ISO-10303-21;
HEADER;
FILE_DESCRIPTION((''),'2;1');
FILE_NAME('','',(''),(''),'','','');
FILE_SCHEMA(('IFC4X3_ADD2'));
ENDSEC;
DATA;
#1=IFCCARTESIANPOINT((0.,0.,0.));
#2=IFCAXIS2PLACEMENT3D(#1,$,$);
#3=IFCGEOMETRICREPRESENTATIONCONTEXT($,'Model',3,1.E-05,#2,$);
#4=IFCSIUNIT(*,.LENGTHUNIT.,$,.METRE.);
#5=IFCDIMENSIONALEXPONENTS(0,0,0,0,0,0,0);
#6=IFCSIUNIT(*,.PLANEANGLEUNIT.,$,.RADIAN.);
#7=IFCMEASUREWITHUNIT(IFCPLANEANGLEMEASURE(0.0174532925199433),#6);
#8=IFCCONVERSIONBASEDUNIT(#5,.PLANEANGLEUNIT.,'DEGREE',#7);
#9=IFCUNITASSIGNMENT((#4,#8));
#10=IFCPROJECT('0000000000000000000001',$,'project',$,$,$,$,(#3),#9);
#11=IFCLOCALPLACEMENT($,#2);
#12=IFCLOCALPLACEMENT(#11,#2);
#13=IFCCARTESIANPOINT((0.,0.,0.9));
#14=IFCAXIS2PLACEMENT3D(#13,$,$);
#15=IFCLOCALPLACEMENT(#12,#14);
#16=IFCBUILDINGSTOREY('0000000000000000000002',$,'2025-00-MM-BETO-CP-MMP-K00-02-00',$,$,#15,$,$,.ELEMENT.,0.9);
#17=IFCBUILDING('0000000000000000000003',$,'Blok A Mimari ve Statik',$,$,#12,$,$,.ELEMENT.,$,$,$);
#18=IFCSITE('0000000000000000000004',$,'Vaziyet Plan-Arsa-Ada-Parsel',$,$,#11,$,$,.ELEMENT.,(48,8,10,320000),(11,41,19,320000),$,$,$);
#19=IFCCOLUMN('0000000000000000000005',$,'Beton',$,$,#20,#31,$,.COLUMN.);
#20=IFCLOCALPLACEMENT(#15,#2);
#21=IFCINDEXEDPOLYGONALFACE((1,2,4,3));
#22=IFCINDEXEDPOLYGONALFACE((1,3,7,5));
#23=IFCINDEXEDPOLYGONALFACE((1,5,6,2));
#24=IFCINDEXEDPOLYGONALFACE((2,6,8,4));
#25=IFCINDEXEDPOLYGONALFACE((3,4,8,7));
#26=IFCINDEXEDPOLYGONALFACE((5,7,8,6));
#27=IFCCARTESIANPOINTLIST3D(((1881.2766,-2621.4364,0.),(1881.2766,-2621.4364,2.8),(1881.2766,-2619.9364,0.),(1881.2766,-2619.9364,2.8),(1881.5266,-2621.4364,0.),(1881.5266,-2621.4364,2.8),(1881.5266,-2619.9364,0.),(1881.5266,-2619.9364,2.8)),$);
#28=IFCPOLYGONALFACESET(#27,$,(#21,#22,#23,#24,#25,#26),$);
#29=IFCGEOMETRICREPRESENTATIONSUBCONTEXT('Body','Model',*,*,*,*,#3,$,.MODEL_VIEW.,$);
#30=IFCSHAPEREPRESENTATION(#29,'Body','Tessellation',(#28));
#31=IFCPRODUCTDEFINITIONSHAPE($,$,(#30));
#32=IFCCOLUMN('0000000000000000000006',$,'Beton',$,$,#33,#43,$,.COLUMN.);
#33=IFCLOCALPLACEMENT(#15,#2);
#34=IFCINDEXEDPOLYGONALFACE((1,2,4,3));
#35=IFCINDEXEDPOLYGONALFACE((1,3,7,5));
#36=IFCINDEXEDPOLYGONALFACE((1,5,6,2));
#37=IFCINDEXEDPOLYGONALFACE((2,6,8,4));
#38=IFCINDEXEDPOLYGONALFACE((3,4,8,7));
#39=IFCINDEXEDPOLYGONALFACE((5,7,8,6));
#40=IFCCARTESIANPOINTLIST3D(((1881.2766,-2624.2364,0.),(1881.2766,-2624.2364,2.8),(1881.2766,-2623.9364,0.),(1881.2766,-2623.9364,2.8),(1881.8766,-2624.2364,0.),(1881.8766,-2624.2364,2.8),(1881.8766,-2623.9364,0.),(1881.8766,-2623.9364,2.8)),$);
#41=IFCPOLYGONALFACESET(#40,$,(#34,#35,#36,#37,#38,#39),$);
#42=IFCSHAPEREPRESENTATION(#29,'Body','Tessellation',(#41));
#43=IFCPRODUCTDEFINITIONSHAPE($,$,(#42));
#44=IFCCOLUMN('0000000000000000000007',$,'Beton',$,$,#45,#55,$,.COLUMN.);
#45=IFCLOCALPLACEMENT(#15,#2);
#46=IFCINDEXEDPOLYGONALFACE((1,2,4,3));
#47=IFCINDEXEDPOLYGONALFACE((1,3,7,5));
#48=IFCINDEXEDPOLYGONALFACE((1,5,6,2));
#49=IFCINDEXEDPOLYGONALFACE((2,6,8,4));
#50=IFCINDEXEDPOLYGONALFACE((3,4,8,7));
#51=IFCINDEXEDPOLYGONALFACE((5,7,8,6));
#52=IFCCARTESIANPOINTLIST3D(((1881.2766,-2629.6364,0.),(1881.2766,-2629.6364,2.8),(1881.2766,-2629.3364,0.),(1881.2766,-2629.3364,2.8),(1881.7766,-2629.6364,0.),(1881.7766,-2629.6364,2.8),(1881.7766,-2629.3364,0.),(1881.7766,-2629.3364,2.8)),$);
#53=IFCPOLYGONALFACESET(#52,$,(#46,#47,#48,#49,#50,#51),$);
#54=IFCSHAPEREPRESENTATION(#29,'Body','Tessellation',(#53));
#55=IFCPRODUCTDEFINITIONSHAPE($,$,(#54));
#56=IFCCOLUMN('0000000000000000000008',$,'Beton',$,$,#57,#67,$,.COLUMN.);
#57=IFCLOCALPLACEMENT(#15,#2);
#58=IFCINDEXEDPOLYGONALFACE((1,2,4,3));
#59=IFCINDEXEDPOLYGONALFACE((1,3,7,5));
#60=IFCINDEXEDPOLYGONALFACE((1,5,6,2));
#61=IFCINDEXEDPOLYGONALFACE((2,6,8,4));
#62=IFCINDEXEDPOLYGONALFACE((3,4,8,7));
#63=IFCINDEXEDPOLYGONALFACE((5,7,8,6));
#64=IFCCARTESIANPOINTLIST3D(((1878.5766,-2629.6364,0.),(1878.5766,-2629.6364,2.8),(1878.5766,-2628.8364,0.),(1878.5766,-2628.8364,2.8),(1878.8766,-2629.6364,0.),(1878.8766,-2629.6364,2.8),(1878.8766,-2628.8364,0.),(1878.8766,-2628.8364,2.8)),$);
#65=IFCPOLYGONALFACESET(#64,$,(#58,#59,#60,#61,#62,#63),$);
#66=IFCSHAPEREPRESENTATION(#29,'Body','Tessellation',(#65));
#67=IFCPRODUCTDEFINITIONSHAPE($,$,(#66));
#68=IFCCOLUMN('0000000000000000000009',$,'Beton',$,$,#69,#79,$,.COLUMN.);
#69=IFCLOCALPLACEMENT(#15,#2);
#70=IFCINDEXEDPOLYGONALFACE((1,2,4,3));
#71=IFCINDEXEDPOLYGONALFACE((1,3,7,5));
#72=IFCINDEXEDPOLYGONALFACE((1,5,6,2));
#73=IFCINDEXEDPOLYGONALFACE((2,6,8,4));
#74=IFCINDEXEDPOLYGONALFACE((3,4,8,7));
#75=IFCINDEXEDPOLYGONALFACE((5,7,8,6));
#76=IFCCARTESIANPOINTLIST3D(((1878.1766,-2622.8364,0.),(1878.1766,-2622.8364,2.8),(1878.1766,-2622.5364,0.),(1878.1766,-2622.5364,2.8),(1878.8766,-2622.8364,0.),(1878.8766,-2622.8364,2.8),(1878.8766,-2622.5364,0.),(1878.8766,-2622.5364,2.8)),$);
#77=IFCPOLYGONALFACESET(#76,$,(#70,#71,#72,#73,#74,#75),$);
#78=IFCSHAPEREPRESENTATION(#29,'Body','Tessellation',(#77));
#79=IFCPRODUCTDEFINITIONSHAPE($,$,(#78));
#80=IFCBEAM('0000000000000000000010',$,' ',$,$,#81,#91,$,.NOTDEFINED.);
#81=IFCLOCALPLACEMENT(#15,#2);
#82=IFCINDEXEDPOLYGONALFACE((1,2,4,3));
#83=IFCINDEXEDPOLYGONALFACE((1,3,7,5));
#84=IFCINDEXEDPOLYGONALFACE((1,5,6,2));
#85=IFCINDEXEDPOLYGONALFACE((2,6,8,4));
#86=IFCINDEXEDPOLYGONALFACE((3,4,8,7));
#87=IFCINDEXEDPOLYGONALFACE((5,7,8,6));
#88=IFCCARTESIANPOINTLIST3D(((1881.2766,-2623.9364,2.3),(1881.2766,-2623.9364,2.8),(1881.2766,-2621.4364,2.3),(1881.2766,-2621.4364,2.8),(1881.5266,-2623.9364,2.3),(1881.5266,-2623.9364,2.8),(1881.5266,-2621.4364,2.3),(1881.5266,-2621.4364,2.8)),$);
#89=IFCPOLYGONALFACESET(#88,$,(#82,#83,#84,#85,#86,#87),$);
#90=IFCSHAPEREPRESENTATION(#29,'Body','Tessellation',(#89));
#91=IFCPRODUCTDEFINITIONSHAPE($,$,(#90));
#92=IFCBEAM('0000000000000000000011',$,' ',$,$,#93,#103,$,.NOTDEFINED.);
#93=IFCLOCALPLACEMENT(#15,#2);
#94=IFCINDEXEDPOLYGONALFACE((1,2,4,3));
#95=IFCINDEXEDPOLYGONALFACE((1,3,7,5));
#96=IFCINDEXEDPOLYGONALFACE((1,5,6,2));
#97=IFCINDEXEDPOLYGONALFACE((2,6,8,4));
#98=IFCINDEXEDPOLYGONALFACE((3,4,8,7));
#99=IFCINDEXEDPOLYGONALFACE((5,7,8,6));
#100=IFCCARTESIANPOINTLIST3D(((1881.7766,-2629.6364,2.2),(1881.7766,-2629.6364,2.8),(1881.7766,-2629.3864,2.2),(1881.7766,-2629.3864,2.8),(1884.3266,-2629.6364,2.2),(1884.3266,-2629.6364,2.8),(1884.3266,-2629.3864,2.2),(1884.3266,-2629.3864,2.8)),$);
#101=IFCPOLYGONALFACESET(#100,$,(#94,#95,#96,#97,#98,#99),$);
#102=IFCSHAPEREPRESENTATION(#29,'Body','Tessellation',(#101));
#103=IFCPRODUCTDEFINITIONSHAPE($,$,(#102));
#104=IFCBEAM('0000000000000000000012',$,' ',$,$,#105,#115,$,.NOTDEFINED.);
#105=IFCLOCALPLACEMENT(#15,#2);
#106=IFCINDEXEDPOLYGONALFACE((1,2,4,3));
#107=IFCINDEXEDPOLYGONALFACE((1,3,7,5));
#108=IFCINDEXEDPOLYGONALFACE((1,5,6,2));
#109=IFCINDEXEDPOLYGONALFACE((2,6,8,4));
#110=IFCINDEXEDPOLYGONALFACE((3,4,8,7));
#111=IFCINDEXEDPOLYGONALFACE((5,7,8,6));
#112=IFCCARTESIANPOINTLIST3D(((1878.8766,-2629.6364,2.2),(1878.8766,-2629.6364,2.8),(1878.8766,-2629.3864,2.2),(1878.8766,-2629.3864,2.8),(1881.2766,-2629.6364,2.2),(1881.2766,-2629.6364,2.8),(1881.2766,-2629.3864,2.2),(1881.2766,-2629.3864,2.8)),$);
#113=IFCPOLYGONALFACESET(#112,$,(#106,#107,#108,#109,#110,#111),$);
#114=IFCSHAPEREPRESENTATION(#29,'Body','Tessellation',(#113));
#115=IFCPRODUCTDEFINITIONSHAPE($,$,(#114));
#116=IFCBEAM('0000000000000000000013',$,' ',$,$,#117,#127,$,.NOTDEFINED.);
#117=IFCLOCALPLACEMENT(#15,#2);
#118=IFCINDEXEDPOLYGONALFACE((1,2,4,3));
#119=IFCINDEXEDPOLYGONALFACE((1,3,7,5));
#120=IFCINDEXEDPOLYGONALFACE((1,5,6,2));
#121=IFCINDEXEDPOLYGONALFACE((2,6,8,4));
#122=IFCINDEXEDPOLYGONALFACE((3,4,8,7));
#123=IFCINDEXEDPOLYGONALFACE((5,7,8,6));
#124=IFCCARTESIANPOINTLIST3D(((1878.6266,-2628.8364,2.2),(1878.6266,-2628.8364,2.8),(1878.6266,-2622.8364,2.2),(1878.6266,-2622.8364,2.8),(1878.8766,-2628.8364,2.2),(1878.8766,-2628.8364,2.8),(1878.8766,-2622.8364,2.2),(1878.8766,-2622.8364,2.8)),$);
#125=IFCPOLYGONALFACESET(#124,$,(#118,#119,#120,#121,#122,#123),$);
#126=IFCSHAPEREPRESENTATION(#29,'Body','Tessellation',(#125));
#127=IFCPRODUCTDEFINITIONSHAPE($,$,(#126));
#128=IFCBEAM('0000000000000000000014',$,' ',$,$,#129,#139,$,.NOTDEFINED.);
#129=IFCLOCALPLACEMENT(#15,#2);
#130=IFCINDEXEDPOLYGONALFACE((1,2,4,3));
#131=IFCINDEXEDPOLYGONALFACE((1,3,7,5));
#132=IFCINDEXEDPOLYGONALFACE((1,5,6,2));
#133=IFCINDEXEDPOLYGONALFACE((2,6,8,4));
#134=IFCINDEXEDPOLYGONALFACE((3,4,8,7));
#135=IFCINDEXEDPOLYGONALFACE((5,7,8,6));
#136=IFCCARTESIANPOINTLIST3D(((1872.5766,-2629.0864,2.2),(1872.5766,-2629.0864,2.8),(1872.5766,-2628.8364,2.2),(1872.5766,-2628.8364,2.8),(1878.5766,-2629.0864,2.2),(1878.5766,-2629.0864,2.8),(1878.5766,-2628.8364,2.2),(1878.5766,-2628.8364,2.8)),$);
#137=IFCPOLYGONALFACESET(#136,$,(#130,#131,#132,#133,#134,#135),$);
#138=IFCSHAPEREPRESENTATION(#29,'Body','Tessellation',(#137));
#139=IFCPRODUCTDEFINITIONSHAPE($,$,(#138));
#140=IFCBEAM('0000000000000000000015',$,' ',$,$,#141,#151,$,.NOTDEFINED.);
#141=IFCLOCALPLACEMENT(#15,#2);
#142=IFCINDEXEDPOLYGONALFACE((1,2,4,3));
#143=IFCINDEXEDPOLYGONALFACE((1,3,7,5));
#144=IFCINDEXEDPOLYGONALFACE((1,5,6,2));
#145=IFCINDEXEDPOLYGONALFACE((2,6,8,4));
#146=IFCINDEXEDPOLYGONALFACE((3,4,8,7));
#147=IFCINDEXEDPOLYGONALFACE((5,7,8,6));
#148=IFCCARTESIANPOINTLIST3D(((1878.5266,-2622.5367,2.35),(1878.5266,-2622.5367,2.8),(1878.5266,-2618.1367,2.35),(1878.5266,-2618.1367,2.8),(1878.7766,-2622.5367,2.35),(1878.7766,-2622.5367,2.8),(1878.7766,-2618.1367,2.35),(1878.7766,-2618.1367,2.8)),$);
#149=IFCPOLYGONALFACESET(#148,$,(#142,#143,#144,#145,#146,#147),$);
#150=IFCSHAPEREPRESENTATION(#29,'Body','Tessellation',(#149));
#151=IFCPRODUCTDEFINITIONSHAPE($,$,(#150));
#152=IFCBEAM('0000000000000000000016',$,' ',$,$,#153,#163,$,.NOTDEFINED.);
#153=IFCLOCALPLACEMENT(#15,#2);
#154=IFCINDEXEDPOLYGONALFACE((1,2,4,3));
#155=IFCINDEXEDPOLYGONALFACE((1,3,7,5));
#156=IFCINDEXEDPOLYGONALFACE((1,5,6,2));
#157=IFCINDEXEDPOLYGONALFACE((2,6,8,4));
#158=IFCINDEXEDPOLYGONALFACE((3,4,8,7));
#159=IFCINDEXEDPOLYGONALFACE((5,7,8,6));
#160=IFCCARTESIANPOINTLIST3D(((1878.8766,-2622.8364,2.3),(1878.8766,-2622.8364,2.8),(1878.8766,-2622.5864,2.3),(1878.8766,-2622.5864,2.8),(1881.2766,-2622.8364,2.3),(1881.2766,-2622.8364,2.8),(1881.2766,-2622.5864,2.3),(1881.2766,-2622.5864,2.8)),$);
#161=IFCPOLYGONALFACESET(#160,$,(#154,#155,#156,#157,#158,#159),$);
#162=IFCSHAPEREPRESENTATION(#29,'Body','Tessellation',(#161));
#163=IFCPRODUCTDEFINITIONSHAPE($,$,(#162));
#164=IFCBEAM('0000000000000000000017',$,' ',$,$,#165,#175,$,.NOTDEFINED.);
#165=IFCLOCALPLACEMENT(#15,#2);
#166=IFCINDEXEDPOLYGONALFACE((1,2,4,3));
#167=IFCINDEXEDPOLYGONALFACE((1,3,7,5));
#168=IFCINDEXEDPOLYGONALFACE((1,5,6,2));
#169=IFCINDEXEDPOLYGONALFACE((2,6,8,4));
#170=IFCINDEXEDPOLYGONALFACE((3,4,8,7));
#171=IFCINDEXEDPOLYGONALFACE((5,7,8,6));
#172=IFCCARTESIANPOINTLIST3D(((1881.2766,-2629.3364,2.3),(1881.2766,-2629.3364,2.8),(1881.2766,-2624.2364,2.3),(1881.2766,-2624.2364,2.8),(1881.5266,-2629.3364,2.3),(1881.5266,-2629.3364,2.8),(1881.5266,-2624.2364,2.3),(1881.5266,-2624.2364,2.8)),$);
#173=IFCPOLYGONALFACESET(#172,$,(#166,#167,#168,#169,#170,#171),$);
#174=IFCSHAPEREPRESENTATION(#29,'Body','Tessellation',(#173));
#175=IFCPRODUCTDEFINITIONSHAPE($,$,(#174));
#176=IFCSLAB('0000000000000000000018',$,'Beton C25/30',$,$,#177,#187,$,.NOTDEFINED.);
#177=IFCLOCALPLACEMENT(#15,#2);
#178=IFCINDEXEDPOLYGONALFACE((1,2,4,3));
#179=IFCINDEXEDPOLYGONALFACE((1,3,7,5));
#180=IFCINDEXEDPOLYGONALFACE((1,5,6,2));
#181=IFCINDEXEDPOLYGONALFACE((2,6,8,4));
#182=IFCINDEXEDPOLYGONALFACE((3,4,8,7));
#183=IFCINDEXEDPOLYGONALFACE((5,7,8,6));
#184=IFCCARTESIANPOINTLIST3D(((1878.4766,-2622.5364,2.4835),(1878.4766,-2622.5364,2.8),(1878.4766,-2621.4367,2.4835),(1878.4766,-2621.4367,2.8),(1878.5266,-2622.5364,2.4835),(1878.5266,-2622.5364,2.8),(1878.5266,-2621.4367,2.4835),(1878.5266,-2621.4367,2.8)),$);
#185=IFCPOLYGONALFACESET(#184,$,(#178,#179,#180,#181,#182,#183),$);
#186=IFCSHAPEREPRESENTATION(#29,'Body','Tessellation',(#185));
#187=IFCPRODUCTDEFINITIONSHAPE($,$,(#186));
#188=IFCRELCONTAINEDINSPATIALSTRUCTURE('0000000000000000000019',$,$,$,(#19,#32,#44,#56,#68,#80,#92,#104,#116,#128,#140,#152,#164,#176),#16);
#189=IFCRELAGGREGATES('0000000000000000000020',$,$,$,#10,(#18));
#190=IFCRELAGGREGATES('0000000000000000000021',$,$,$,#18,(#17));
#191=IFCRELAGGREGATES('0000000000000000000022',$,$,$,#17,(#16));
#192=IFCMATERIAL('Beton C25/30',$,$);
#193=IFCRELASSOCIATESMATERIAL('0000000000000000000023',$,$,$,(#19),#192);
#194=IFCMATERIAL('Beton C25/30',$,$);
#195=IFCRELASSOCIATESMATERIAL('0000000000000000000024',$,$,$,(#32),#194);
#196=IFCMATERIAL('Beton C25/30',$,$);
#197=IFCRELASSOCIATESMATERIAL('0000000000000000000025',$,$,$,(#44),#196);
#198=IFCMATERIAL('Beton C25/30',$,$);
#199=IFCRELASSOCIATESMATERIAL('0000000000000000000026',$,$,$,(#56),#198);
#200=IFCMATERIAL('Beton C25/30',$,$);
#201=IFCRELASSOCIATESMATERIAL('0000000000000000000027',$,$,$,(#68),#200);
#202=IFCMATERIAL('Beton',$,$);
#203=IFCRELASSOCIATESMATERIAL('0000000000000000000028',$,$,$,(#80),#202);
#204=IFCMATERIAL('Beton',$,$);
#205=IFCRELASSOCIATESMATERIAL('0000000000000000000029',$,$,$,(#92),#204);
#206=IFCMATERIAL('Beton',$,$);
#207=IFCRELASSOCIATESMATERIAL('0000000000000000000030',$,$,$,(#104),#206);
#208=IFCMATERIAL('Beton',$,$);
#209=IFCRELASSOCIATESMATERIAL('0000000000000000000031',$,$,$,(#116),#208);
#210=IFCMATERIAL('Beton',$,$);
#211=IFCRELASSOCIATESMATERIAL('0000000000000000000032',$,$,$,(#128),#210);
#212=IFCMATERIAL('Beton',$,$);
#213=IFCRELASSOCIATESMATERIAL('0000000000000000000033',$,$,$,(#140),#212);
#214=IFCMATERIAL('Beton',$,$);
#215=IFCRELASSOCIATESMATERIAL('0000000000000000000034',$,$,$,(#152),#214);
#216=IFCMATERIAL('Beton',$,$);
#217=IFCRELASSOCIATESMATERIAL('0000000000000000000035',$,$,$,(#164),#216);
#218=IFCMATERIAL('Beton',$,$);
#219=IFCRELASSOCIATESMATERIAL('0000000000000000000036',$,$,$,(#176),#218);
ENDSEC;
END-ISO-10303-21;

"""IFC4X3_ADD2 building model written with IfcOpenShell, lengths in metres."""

from ifc_helpers import new_model, entity, si_unit, converted_unit, frame, frame_2d, origin, origin_with_axes, place, context, subcontext, project, spatial, polyline, rectangle, outline, extrude, material, element, save


model = new_model("IFC4X3_ADD2")

# Units and contexts
model_context = context("Model", 3, precision=1e-05, world=origin())
body_context = subcontext(model_context, "Body", "Model", "MODEL_VIEW")
ifc_project = project(units=[si_unit("LENGTHUNIT", "METRE"), converted_unit("PLANEANGLEUNIT", "DEGREE", entity("IfcPlaneAngleMeasure", 0.0174532925199433), si_unit("PLANEANGLEUNIT", "RADIAN"), dimensions=[0, 0, 0, 0, 0, 0, 0])], contexts=[model_context])

# Site, building, storey
site_placement = place(None, origin())
site = spatial("IfcSite", under=ifc_project, at=site_placement, Name="Vaziyet Plan-Arsa-Ada-Parsel", CompositionType="ELEMENT", RefLatitude=(48, 8, 10, 320000), RefLongitude=(11, 41, 19, 320000))
building_placement = place(site_placement, origin())
building = spatial("IfcBuilding", under=site, at=building_placement, Name="Blok A Mimari ve Statik", CompositionType="ELEMENT")
storey_placement = place(building_placement, frame((0.0, 0.0, 0.9)))
storey = spatial("IfcBuildingStorey", under=building, at=storey_placement, Name="2025-00-MM-BETO-CP-MMP-K00-02-00", CompositionType="ELEMENT", Elevation=0.9)

# Columns
ifc_material_1 = material(Name="Beton C25/30")
column_1_placement = place(storey_placement, frame((1881.2766, -2621.4364, 0.0)))
element("IfcColumn", 1, at=column_1_placement, inside=storey, material=ifc_material_1, Name="Beton", PredefinedType="COLUMN", context=body_context, shape_type="SweptSolid", body=[
    extrude(outline(polyline([(0.0, 0.0), (0.25, 0.0), (0.25, 1.5), (0.0, 1.5), (0.0, 0.0)])), origin_with_axes(), (0.0, 0.0, 1.0), 2.8),
])
ifc_material_2 = material(Name="Beton C25/30")
column_2_placement = place(storey_placement, frame((1881.2766, -2624.2364, 0.0)))
element("IfcColumn", 2, at=column_2_placement, inside=storey, material=ifc_material_2, Name="Beton", PredefinedType="COLUMN", context=body_context, shape_type="SweptSolid", body=[
    extrude(outline(polyline([(0.0, 0.0), (0.6, 0.0), (0.6, 0.3), (0.0, 0.3), (0.0, 0.0)])), origin_with_axes(), (0.0, 0.0, 1.0), 2.8),
])
ifc_material_3 = material(Name="Beton C25/30")
column_3_placement = place(storey_placement, frame((1881.2766, -2629.6364, 0.0)))
element("IfcColumn", 3, at=column_3_placement, inside=storey, material=ifc_material_3, Name="Beton", PredefinedType="COLUMN", context=body_context, shape_type="SweptSolid", body=[
    extrude(outline(polyline([(0.0, 0.3), (0.0, 0.0), (0.5, 0.0), (0.5, 0.3), (0.0, 0.3)])), origin_with_axes(), (0.0, 0.0, 1.0), 2.8),
])
ifc_material_4 = material(Name="Beton C25/30")
column_4_placement = place(storey_placement, frame((1878.5766, -2629.6364, 0.0)))
element("IfcColumn", 4, at=column_4_placement, inside=storey, material=ifc_material_4, Name="Beton", PredefinedType="COLUMN", context=body_context, shape_type="SweptSolid", body=[
    extrude(outline(polyline([(0.0, 0.0), (0.3, 0.0), (0.3, 0.8), (0.0, 0.8), (0.0, 0.0)])), origin_with_axes(), (0.0, 0.0, 1.0), 2.8),
])
ifc_material_5 = material(Name="Beton C25/30")
column_5_placement = place(storey_placement, frame((1878.1766, -2622.8364, 0.0)))
element("IfcColumn", 5, at=column_5_placement, inside=storey, material=ifc_material_5, Name="Beton", PredefinedType="COLUMN", context=body_context, shape_type="SweptSolid", body=[
    extrude(outline(polyline([(0.0, 0.0), (0.7, 0.0), (0.7, 0.3), (0.0, 0.3), (0.0, 0.0)])), origin_with_axes(), (0.0, 0.0, 1.0), 2.8),
])

# Beams
ifc_material_6 = material(Name="Beton")
beam_1_placement = place(storey_placement, frame((1881.2766, -2621.4364, 2.3), z_axis=(0.0, 0.0, 1.0), x_axis=(0.0, -1.0, 0.0)))
element("IfcBeam", 6, at=beam_1_placement, inside=storey, material=ifc_material_6, Name=" ", PredefinedType="NOTDEFINED", context=body_context, shape_type="SweptSolid", body=[
    extrude(rectangle(XDim=0.25, YDim=0.5, at=frame_2d((0.125, 0.25), x_axis=(1.0, 0.0))), frame((0.0, 0.0, 0.0), z_axis=(1.0, 0.0, 0.0), x_axis=(0.0, 1.0, 0.0)), (0.0, 0.0, 1.0), 2.5),
])
ifc_material_7 = material(Name="Beton")
beam_2_placement = place(storey_placement, frame((1881.7766, -2629.6364, 2.2), z_axis=(0.0, 0.0, 1.0), x_axis=(1.0, 0.0, 0.0)))
element("IfcBeam", 7, at=beam_2_placement, inside=storey, material=ifc_material_7, Name=" ", PredefinedType="NOTDEFINED", context=body_context, shape_type="SweptSolid", body=[
    extrude(rectangle(XDim=0.25, YDim=0.6, at=frame_2d((0.125, 0.3), x_axis=(1.0, 0.0))), frame((0.0, 0.0, 0.0), z_axis=(1.0, 0.0, 0.0), x_axis=(0.0, 1.0, 0.0)), (0.0, 0.0, 1.0), 2.55),
])
ifc_material_8 = material(Name="Beton")
beam_3_placement = place(storey_placement, frame((1878.8766, -2629.6364, 2.2)))
element("IfcBeam", 8, at=beam_3_placement, inside=storey, material=ifc_material_8, Name=" ", PredefinedType="NOTDEFINED", context=body_context, shape_type="SweptSolid", body=[
    extrude(rectangle(XDim=0.25, YDim=0.6, at=frame_2d((0.125, 0.3), x_axis=(1.0, 0.0))), frame((0.0, 0.0, 0.0), z_axis=(1.0, 0.0, 0.0), x_axis=(0.0, 1.0, 0.0)), (0.0, 0.0, 1.0), 2.4),
])
ifc_material_9 = material(Name="Beton")
beam_4_placement = place(storey_placement, frame((1878.8766, -2628.8364, 2.2), z_axis=(0.0, 0.0, 1.0), x_axis=(0.0, 1.0, 0.0)))
element("IfcBeam", 9, at=beam_4_placement, inside=storey, material=ifc_material_9, Name=" ", PredefinedType="NOTDEFINED", context=body_context, shape_type="SweptSolid", body=[
    extrude(rectangle(XDim=0.25, YDim=0.6, at=frame_2d((0.125, 0.3), x_axis=(1.0, 0.0))), frame((0.0, 0.0, 0.0), z_axis=(1.0, 0.0, 0.0), x_axis=(0.0, 1.0, 0.0)), (0.0, 0.0, 1.0), 6.0),
])
ifc_material_10 = material(Name="Beton")
beam_5_placement = place(storey_placement, frame((1878.5766, -2628.8364, 2.2), z_axis=(0.0, 0.0, 1.0), x_axis=(-1.0, 0.0, 0.0)))
element("IfcBeam", 10, at=beam_5_placement, inside=storey, material=ifc_material_10, Name=" ", PredefinedType="NOTDEFINED", context=body_context, shape_type="SweptSolid", body=[
    extrude(rectangle(XDim=0.25, YDim=0.6, at=frame_2d((0.125, 0.3), x_axis=(1.0, 0.0))), frame((0.0, 0.0, 0.0), z_axis=(1.0, 0.0, 0.0), x_axis=(0.0, 1.0, 0.0)), (0.0, 0.0, 1.0), 6.0),
])
ifc_material_11 = material(Name="Beton")
beam_6_placement = place(storey_placement, frame((1878.7766, -2622.5367, 2.35), z_axis=(0.0, 0.0, 1.0), x_axis=(0.0, 1.0, 0.0)))
element("IfcBeam", 11, at=beam_6_placement, inside=storey, material=ifc_material_11, Name=" ", PredefinedType="NOTDEFINED", context=body_context, shape_type="SweptSolid", body=[
    extrude(rectangle(XDim=0.25, YDim=0.45, at=frame_2d((0.125, 0.225), x_axis=(1.0, 0.0))), frame((0.0, 0.0, 0.0), z_axis=(1.0, 0.0, 0.0), x_axis=(0.0, 1.0, 0.0)), (0.0, 0.0, 1.0), 4.4),
])
ifc_material_12 = material(Name="Beton")
beam_7_placement = place(storey_placement, frame((1878.8766, -2622.8364, 2.3)))
element("IfcBeam", 12, at=beam_7_placement, inside=storey, material=ifc_material_12, Name=" ", PredefinedType="NOTDEFINED", context=body_context, shape_type="SweptSolid", body=[
    extrude(rectangle(XDim=0.25, YDim=0.5, at=frame_2d((0.125, 0.25), x_axis=(1.0, 0.0))), frame((0.0, 0.0, 0.0), z_axis=(1.0, 0.0, 0.0), x_axis=(0.0, 1.0, 0.0)), (0.0, 0.0, 1.0), 2.4),
])
ifc_material_13 = material(Name="Beton")
beam_8_placement = place(storey_placement, frame((1881.2766, -2624.2364, 2.3), z_axis=(0.0, 0.0, 1.0), x_axis=(0.0, -1.0, 0.0)))
element("IfcBeam", 13, at=beam_8_placement, inside=storey, material=ifc_material_13, Name=" ", PredefinedType="NOTDEFINED", context=body_context, shape_type="SweptSolid", body=[
    extrude(rectangle(XDim=0.25, YDim=0.5, at=frame_2d((0.125, 0.25), x_axis=(1.0, 0.0))), frame((0.0, 0.0, 0.0), z_axis=(1.0, 0.0, 0.0), x_axis=(0.0, 1.0, 0.0)), (0.0, 0.0, 1.0), 5.1),
])

# Slab
ifc_material_14 = material(Name="Beton")
slab_1_placement = place(storey_placement, frame((1878.4766, -2622.5364, 2.4835)))
element("IfcSlab", 14, at=slab_1_placement, inside=storey, material=ifc_material_14, Name="Beton C25/30", PredefinedType="NOTDEFINED", context=body_context, shape_type="SweptSolid", body=[
    extrude(rectangle(XDim=1.0997, YDim=0.05, at=frame_2d((0.025, -0.5498), x_axis=(0.0, -1.0))), frame((0.0, 1.0997, 0.0), z_axis=(0.0, 0.0, 1.0), x_axis=(1.0, 0.0, 0.0)), (0.0, 0.0, 1.0), 0.3165),
])

save(model, "model.ifc")
